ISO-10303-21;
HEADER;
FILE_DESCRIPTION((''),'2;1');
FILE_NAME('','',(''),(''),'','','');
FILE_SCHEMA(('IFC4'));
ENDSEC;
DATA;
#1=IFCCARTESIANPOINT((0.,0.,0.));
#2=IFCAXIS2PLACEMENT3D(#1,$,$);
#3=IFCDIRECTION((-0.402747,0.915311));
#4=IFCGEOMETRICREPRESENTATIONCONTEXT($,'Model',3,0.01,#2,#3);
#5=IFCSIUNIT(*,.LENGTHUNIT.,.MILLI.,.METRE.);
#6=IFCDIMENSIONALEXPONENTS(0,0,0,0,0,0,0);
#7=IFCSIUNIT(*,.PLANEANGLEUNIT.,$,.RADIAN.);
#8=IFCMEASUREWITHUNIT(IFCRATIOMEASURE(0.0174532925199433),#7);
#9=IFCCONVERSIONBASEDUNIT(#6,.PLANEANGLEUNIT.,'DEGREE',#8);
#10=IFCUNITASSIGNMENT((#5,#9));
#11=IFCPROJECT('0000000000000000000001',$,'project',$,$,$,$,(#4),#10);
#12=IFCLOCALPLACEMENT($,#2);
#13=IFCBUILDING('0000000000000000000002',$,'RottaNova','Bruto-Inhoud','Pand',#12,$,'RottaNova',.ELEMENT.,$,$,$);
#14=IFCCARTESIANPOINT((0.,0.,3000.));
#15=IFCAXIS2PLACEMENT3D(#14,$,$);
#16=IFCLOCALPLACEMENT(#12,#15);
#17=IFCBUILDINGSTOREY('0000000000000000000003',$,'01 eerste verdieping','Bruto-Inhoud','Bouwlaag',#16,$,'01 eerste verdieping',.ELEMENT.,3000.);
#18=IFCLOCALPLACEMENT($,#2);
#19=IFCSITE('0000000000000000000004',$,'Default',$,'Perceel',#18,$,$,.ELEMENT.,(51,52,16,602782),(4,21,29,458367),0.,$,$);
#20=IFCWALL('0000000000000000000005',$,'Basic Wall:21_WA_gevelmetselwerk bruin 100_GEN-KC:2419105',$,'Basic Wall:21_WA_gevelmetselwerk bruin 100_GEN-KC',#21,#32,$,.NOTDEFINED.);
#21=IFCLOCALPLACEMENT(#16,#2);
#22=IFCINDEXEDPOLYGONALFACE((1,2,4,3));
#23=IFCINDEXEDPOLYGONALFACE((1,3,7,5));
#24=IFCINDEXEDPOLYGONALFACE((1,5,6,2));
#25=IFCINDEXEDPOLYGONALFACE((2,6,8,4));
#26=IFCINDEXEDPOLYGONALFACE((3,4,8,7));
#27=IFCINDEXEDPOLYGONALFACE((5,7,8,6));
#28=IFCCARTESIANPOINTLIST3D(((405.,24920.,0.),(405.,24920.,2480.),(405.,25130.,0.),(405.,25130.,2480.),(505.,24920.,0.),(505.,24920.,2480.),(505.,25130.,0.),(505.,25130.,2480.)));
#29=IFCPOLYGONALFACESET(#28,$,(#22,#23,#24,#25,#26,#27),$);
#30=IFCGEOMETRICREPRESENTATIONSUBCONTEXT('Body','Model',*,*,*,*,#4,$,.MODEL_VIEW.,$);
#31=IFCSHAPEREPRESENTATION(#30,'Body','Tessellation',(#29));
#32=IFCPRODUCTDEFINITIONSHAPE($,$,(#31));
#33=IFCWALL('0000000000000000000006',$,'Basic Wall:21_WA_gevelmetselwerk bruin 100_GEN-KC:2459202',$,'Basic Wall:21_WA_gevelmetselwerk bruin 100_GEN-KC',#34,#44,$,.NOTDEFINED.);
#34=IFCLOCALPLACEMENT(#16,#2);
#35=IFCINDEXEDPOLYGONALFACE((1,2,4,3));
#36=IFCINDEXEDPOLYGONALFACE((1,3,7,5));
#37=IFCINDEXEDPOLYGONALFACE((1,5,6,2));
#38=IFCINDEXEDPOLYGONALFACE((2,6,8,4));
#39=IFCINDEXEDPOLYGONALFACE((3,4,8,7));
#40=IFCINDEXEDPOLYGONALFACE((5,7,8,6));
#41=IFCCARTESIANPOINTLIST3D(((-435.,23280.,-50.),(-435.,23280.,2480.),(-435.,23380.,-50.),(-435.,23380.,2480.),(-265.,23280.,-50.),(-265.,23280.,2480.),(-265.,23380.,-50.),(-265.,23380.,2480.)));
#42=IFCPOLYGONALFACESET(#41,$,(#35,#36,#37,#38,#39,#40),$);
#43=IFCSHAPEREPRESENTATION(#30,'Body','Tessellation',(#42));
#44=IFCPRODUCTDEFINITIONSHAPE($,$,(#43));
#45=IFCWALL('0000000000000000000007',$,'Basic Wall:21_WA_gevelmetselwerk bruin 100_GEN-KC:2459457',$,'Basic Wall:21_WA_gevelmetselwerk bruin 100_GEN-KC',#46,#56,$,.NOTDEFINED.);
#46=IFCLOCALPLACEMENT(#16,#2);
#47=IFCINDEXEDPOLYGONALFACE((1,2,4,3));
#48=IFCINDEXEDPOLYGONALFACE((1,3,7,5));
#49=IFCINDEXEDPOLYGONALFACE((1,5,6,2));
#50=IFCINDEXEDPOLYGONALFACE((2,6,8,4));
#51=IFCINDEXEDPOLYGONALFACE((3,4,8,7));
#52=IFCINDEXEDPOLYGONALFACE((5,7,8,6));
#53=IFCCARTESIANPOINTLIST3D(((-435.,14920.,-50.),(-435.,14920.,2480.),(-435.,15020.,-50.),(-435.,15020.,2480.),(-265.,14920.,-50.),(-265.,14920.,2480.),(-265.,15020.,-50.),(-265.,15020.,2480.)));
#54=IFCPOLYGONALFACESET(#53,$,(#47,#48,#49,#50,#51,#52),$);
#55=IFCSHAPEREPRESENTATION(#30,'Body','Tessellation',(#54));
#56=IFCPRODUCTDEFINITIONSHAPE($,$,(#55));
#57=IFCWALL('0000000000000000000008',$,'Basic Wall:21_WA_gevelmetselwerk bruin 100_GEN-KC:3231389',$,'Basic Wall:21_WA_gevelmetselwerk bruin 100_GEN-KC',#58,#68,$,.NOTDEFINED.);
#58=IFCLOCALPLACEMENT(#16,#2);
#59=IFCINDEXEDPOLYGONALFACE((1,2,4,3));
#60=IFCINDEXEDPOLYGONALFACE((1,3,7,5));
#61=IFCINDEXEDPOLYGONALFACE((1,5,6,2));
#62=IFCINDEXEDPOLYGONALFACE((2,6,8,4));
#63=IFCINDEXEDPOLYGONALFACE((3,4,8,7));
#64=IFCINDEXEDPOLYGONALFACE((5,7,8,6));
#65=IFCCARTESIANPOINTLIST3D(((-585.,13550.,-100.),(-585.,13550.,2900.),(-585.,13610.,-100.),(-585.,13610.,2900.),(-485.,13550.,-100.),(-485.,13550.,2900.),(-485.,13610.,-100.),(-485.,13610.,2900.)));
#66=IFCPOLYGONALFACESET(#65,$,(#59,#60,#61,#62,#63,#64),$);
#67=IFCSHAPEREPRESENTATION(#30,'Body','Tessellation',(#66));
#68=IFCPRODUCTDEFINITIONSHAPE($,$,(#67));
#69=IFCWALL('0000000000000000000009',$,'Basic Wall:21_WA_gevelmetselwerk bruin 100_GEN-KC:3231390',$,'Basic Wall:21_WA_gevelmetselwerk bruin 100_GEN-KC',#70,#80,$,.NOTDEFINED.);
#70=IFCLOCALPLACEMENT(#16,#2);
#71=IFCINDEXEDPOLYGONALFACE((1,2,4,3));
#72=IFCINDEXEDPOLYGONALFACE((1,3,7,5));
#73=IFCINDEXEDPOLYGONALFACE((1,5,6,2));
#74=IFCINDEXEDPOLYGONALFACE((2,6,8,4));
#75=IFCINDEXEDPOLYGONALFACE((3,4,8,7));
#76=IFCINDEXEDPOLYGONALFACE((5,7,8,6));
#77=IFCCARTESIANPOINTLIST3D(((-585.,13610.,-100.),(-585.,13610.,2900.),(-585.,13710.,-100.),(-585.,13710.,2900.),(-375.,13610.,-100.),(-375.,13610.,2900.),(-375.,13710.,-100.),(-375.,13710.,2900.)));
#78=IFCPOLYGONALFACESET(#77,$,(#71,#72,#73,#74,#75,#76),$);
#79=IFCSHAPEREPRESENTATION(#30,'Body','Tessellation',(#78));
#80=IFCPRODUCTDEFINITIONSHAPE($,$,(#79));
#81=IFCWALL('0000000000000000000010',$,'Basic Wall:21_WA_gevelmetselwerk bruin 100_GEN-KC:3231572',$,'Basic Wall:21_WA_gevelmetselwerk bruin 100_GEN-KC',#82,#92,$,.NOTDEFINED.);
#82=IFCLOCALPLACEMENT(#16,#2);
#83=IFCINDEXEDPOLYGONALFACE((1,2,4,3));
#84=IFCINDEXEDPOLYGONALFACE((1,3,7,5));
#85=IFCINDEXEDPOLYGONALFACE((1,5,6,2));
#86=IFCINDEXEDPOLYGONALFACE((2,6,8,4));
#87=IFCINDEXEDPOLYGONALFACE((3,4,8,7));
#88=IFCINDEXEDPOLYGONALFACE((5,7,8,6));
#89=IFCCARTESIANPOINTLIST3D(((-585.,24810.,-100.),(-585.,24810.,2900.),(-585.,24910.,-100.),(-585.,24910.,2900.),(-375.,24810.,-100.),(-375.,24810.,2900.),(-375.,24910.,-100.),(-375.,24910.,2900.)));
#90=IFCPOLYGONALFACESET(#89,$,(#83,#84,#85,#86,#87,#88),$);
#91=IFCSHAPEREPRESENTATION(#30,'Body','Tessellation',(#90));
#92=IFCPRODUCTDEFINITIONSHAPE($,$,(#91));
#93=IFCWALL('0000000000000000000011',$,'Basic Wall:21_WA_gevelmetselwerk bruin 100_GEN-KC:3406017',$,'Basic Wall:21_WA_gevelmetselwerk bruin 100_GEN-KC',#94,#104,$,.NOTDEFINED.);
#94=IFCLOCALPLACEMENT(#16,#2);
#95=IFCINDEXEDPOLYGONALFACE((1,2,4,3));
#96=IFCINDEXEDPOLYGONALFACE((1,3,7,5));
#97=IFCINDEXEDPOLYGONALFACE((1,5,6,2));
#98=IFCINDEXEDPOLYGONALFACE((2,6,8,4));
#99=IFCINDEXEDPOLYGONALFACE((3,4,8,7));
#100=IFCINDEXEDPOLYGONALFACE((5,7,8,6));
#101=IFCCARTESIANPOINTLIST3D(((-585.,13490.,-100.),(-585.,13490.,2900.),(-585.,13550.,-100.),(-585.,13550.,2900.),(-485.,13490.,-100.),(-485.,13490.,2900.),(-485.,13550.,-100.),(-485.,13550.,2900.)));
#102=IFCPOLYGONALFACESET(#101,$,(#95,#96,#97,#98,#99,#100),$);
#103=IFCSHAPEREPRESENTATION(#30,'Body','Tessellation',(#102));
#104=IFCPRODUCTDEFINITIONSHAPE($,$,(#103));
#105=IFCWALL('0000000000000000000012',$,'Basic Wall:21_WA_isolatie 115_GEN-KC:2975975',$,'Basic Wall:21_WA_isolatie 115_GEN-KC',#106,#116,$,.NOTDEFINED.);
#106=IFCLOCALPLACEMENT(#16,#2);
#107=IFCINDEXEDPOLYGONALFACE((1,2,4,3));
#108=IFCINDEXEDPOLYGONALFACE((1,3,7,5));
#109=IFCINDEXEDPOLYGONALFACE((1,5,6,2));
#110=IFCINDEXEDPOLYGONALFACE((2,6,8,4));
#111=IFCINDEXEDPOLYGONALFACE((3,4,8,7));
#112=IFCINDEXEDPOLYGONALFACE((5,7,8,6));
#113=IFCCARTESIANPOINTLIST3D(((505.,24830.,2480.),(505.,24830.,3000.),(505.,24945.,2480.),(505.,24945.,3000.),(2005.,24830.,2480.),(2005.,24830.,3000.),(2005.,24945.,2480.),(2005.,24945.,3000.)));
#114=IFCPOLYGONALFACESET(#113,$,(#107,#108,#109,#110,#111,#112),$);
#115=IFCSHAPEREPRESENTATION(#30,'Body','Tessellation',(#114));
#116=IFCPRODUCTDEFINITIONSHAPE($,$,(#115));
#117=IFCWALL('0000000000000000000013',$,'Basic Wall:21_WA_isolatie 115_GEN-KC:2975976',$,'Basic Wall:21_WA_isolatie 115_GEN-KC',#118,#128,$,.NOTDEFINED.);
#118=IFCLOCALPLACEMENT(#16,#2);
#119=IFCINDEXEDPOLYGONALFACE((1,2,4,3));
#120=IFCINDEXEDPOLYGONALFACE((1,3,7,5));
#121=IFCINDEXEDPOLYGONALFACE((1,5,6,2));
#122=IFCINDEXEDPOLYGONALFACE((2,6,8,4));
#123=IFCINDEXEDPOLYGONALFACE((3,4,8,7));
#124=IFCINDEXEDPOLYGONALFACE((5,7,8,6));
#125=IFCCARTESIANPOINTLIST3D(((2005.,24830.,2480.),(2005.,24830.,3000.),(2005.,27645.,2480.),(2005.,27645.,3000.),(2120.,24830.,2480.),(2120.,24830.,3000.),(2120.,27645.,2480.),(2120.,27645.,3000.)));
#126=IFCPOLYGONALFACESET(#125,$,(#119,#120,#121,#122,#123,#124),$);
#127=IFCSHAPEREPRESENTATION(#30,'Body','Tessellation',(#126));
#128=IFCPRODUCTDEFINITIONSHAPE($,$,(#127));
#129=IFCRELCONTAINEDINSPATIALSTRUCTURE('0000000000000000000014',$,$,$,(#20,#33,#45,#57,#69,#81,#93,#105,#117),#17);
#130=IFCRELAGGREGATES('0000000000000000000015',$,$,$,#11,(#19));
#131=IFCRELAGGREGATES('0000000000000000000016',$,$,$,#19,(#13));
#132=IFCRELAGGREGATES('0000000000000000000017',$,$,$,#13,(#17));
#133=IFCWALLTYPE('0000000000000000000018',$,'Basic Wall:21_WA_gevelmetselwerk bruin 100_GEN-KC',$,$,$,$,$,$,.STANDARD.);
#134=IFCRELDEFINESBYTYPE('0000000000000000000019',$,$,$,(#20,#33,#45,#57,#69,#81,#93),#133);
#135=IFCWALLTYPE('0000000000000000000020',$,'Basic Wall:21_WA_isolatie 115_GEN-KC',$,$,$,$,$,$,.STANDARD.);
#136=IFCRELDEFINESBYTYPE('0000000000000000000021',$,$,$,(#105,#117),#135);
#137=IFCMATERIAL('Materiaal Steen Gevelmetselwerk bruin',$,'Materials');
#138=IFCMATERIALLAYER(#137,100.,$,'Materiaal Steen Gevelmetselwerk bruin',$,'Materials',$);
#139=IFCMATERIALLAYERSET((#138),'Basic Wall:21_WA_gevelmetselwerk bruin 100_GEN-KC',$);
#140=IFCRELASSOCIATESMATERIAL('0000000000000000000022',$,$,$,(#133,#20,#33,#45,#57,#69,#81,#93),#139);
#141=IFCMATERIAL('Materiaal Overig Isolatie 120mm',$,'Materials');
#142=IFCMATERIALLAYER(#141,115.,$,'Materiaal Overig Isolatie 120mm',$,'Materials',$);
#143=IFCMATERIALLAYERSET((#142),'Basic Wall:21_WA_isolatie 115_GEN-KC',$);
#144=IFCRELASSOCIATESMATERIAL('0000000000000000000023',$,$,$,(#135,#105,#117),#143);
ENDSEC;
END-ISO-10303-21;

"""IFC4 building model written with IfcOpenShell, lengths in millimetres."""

from ifc_helpers import new_model, entity, si_unit, converted_unit, direction, frame, frame_2d, origin, place, context, subcontext, project, spatial, rectangle, extrude, material, layer, layer_set, type_object, element, save


model = new_model("IFC4")

# Units and contexts
model_context = context("Model", 3, precision=0.01, world=origin(), true_north=direction((-0.402747, 0.915311)))
body_context = subcontext(model_context, "Body", "Model", "MODEL_VIEW")
ifc_project = project(units=[si_unit("LENGTHUNIT", "METRE", prefix="MILLI"), converted_unit("PLANEANGLEUNIT", "DEGREE", entity("IfcRatioMeasure", 0.0174532925199433), si_unit("PLANEANGLEUNIT", "RADIAN"), dimensions=[0, 0, 0, 0, 0, 0, 0])], contexts=[model_context])

# Site, building, storey
site_placement = place(None, origin())
site = spatial("IfcSite", under=ifc_project, at=site_placement, Name="Default", ObjectType="Perceel", CompositionType="ELEMENT", RefLatitude=(51, 52, 16, 602782), RefLongitude=(4, 21, 29, 458367), RefElevation=0.0)
building_placement = place(None, origin())
building = spatial("IfcBuilding", under=site, at=building_placement, Name="RottaNova", Description="Bruto-Inhoud", ObjectType="Pand", LongName="RottaNova", CompositionType="ELEMENT")
storey_placement = place(building_placement, frame((0.0, 0.0, 3000.0)))
storey = spatial("IfcBuildingStorey", under=building, at=storey_placement, Name="01 eerste verdieping", Description="Bruto-Inhoud", ObjectType="Bouwlaag", LongName="01 eerste verdieping", CompositionType="ELEMENT", Elevation=3000.0)

# Walls
ifc_material_1 = material(Name="Materiaal Steen Gevelmetselwerk bruin", Category="Materials")
ifc_layer_1 = layer(ifc_material_1, 100.0, Name="Materiaal Steen Gevelmetselwerk bruin", Category="Materials")
ifc_layer_set_1 = layer_set([ifc_layer_1], Name="Basic Wall:21_WA_gevelmetselwerk bruin 100_GEN-KC")
wall_type_1 = type_object("IfcWallType", Name="Basic Wall:21_WA_gevelmetselwerk bruin 100_GEN-KC", PredefinedType="STANDARD", material=ifc_layer_set_1)
wall_1_placement = place(storey_placement, frame((455.0, 24920.0, 0.0), z_axis=(0.0, 0.0, 1.0), x_axis=(0.0, 1.0, 0.0)))
element("IfcWall", 1, at=wall_1_placement, inside=storey, type_object=wall_type_1, material=ifc_layer_set_1, Name="Basic Wall:21_WA_gevelmetselwerk bruin 100_GEN-KC:2419105", ObjectType="Basic Wall:21_WA_gevelmetselwerk bruin 100_GEN-KC", PredefinedType="NOTDEFINED", context=body_context, shape_type="SweptSolid", body=[
    extrude(rectangle(XDim=210.0, YDim=100.0, at=frame_2d((105.0, 0.0), x_axis=(-1.0, 0.0))), origin(), (0.0, 0.0, 1.0), 2480.0),
])
wall_2_placement = place(storey_placement, frame((-435.0, 23330.0, -50.0)))
element("IfcWall", 2, at=wall_2_placement, inside=storey, type_object=wall_type_1, material=ifc_layer_set_1, Name="Basic Wall:21_WA_gevelmetselwerk bruin 100_GEN-KC:2459202", ObjectType="Basic Wall:21_WA_gevelmetselwerk bruin 100_GEN-KC", PredefinedType="NOTDEFINED", context=body_context, shape_type="SweptSolid", body=[
    extrude(rectangle(XDim=170.0, YDim=100.0, at=frame_2d((85.0, 0.0), x_axis=(-1.0, 0.0))), origin(), (0.0, 0.0, 1.0), 2530.0),
])
wall_3_placement = place(storey_placement, frame((-435.0, 14970.0, -50.0)))
element("IfcWall", 3, at=wall_3_placement, inside=storey, type_object=wall_type_1, material=ifc_layer_set_1, Name="Basic Wall:21_WA_gevelmetselwerk bruin 100_GEN-KC:2459457", ObjectType="Basic Wall:21_WA_gevelmetselwerk bruin 100_GEN-KC", PredefinedType="NOTDEFINED", context=body_context, shape_type="SweptSolid", body=[
    extrude(rectangle(XDim=170.0, YDim=100.0, at=frame_2d((85.0, 0.0), x_axis=(-1.0, 0.0))), origin(), (0.0, 0.0, 1.0), 2530.0),
])
wall_4_placement = place(storey_placement, frame((-535.0, 13550.0, -100.0), z_axis=(0.0, 0.0, 1.0), x_axis=(0.0, 1.0, 0.0)))
element("IfcWall", 4, at=wall_4_placement, inside=storey, type_object=wall_type_1, material=ifc_layer_set_1, Name="Basic Wall:21_WA_gevelmetselwerk bruin 100_GEN-KC:3231389", ObjectType="Basic Wall:21_WA_gevelmetselwerk bruin 100_GEN-KC", PredefinedType="NOTDEFINED", context=body_context, shape_type="SweptSolid", body=[
    extrude(rectangle(XDim=60.0, YDim=100.0, at=frame_2d((30.0, 0.0), x_axis=(-1.0, 0.0))), origin(), (0.0, 0.0, 1.0), 3000.0),
])
wall_5_placement = place(storey_placement, frame((-585.0, 13660.0, -100.0)))
element("IfcWall", 5, at=wall_5_placement, inside=storey, type_object=wall_type_1, material=ifc_layer_set_1, Name="Basic Wall:21_WA_gevelmetselwerk bruin 100_GEN-KC:3231390", ObjectType="Basic Wall:21_WA_gevelmetselwerk bruin 100_GEN-KC", PredefinedType="NOTDEFINED", context=body_context, shape_type="SweptSolid", body=[
    extrude(rectangle(XDim=210.0, YDim=100.0, at=frame_2d((105.0, 0.0), x_axis=(-1.0, 0.0))), origin(), (0.0, 0.0, 1.0), 3000.0),
])
wall_6_placement = place(storey_placement, frame((-585.0, 24860.0, -100.0)))
element("IfcWall", 6, at=wall_6_placement, inside=storey, type_object=wall_type_1, material=ifc_layer_set_1, Name="Basic Wall:21_WA_gevelmetselwerk bruin 100_GEN-KC:3231572", ObjectType="Basic Wall:21_WA_gevelmetselwerk bruin 100_GEN-KC", PredefinedType="NOTDEFINED", context=body_context, shape_type="SweptSolid", body=[
    extrude(rectangle(XDim=210.0, YDim=100.0, at=frame_2d((105.0, 0.0), x_axis=(-1.0, 0.0))), origin(), (0.0, 0.0, 1.0), 3000.0),
])
wall_7_placement = place(storey_placement, frame((-535.0, 13490.0, -100.0), z_axis=(0.0, 0.0, 1.0), x_axis=(0.0, 1.0, 0.0)))
element("IfcWall", 7, at=wall_7_placement, inside=storey, type_object=wall_type_1, material=ifc_layer_set_1, Name="Basic Wall:21_WA_gevelmetselwerk bruin 100_GEN-KC:3406017", ObjectType="Basic Wall:21_WA_gevelmetselwerk bruin 100_GEN-KC", PredefinedType="NOTDEFINED", context=body_context, shape_type="SweptSolid", body=[
    extrude(rectangle(XDim=60.0, YDim=100.0, at=frame_2d((30.0, 0.0), x_axis=(-1.0, 0.0))), origin(), (0.0, 0.0, 1.0), 3000.0),
])
ifc_material_2 = material(Name="Materiaal Overig Isolatie 120mm", Category="Materials")
ifc_layer_2 = layer(ifc_material_2, 115.0, Name="Materiaal Overig Isolatie 120mm", Category="Materials")
ifc_layer_set_2 = layer_set([ifc_layer_2], Name="Basic Wall:21_WA_isolatie 115_GEN-KC")
wall_type_2 = type_object("IfcWallType", Name="Basic Wall:21_WA_isolatie 115_GEN-KC", PredefinedType="STANDARD", material=ifc_layer_set_2)
wall_8_placement = place(storey_placement, frame((505.0, 24887.5, 2480.0)))
element("IfcWall", 8, at=wall_8_placement, inside=storey, type_object=wall_type_2, material=ifc_layer_set_2, Name="Basic Wall:21_WA_isolatie 115_GEN-KC:2975975", ObjectType="Basic Wall:21_WA_isolatie 115_GEN-KC", PredefinedType="NOTDEFINED", context=body_context, shape_type="SweptSolid", body=[
    extrude(rectangle(XDim=1500.0, YDim=115.0, at=frame_2d((750.0, 0.0), x_axis=(-1.0, 0.0))), origin(), (0.0, 0.0, 1.0), 520.0),
])
wall_9_placement = place(storey_placement, frame((2062.5, 24830.0, 2480.0), z_axis=(0.0, 0.0, 1.0), x_axis=(0.0, 1.0, 0.0)))
element("IfcWall", 9, at=wall_9_placement, inside=storey, type_object=wall_type_2, material=ifc_layer_set_2, Name="Basic Wall:21_WA_isolatie 115_GEN-KC:2975976", ObjectType="Basic Wall:21_WA_isolatie 115_GEN-KC", PredefinedType="NOTDEFINED", context=body_context, shape_type="SweptSolid", body=[
    extrude(rectangle(XDim=2815.0, YDim=115.0, at=frame_2d((1407.5, 0.0), x_axis=(-1.0, 0.0))), origin(), (0.0, 0.0, 1.0), 520.0),
])

save(model, "model.ifc")
